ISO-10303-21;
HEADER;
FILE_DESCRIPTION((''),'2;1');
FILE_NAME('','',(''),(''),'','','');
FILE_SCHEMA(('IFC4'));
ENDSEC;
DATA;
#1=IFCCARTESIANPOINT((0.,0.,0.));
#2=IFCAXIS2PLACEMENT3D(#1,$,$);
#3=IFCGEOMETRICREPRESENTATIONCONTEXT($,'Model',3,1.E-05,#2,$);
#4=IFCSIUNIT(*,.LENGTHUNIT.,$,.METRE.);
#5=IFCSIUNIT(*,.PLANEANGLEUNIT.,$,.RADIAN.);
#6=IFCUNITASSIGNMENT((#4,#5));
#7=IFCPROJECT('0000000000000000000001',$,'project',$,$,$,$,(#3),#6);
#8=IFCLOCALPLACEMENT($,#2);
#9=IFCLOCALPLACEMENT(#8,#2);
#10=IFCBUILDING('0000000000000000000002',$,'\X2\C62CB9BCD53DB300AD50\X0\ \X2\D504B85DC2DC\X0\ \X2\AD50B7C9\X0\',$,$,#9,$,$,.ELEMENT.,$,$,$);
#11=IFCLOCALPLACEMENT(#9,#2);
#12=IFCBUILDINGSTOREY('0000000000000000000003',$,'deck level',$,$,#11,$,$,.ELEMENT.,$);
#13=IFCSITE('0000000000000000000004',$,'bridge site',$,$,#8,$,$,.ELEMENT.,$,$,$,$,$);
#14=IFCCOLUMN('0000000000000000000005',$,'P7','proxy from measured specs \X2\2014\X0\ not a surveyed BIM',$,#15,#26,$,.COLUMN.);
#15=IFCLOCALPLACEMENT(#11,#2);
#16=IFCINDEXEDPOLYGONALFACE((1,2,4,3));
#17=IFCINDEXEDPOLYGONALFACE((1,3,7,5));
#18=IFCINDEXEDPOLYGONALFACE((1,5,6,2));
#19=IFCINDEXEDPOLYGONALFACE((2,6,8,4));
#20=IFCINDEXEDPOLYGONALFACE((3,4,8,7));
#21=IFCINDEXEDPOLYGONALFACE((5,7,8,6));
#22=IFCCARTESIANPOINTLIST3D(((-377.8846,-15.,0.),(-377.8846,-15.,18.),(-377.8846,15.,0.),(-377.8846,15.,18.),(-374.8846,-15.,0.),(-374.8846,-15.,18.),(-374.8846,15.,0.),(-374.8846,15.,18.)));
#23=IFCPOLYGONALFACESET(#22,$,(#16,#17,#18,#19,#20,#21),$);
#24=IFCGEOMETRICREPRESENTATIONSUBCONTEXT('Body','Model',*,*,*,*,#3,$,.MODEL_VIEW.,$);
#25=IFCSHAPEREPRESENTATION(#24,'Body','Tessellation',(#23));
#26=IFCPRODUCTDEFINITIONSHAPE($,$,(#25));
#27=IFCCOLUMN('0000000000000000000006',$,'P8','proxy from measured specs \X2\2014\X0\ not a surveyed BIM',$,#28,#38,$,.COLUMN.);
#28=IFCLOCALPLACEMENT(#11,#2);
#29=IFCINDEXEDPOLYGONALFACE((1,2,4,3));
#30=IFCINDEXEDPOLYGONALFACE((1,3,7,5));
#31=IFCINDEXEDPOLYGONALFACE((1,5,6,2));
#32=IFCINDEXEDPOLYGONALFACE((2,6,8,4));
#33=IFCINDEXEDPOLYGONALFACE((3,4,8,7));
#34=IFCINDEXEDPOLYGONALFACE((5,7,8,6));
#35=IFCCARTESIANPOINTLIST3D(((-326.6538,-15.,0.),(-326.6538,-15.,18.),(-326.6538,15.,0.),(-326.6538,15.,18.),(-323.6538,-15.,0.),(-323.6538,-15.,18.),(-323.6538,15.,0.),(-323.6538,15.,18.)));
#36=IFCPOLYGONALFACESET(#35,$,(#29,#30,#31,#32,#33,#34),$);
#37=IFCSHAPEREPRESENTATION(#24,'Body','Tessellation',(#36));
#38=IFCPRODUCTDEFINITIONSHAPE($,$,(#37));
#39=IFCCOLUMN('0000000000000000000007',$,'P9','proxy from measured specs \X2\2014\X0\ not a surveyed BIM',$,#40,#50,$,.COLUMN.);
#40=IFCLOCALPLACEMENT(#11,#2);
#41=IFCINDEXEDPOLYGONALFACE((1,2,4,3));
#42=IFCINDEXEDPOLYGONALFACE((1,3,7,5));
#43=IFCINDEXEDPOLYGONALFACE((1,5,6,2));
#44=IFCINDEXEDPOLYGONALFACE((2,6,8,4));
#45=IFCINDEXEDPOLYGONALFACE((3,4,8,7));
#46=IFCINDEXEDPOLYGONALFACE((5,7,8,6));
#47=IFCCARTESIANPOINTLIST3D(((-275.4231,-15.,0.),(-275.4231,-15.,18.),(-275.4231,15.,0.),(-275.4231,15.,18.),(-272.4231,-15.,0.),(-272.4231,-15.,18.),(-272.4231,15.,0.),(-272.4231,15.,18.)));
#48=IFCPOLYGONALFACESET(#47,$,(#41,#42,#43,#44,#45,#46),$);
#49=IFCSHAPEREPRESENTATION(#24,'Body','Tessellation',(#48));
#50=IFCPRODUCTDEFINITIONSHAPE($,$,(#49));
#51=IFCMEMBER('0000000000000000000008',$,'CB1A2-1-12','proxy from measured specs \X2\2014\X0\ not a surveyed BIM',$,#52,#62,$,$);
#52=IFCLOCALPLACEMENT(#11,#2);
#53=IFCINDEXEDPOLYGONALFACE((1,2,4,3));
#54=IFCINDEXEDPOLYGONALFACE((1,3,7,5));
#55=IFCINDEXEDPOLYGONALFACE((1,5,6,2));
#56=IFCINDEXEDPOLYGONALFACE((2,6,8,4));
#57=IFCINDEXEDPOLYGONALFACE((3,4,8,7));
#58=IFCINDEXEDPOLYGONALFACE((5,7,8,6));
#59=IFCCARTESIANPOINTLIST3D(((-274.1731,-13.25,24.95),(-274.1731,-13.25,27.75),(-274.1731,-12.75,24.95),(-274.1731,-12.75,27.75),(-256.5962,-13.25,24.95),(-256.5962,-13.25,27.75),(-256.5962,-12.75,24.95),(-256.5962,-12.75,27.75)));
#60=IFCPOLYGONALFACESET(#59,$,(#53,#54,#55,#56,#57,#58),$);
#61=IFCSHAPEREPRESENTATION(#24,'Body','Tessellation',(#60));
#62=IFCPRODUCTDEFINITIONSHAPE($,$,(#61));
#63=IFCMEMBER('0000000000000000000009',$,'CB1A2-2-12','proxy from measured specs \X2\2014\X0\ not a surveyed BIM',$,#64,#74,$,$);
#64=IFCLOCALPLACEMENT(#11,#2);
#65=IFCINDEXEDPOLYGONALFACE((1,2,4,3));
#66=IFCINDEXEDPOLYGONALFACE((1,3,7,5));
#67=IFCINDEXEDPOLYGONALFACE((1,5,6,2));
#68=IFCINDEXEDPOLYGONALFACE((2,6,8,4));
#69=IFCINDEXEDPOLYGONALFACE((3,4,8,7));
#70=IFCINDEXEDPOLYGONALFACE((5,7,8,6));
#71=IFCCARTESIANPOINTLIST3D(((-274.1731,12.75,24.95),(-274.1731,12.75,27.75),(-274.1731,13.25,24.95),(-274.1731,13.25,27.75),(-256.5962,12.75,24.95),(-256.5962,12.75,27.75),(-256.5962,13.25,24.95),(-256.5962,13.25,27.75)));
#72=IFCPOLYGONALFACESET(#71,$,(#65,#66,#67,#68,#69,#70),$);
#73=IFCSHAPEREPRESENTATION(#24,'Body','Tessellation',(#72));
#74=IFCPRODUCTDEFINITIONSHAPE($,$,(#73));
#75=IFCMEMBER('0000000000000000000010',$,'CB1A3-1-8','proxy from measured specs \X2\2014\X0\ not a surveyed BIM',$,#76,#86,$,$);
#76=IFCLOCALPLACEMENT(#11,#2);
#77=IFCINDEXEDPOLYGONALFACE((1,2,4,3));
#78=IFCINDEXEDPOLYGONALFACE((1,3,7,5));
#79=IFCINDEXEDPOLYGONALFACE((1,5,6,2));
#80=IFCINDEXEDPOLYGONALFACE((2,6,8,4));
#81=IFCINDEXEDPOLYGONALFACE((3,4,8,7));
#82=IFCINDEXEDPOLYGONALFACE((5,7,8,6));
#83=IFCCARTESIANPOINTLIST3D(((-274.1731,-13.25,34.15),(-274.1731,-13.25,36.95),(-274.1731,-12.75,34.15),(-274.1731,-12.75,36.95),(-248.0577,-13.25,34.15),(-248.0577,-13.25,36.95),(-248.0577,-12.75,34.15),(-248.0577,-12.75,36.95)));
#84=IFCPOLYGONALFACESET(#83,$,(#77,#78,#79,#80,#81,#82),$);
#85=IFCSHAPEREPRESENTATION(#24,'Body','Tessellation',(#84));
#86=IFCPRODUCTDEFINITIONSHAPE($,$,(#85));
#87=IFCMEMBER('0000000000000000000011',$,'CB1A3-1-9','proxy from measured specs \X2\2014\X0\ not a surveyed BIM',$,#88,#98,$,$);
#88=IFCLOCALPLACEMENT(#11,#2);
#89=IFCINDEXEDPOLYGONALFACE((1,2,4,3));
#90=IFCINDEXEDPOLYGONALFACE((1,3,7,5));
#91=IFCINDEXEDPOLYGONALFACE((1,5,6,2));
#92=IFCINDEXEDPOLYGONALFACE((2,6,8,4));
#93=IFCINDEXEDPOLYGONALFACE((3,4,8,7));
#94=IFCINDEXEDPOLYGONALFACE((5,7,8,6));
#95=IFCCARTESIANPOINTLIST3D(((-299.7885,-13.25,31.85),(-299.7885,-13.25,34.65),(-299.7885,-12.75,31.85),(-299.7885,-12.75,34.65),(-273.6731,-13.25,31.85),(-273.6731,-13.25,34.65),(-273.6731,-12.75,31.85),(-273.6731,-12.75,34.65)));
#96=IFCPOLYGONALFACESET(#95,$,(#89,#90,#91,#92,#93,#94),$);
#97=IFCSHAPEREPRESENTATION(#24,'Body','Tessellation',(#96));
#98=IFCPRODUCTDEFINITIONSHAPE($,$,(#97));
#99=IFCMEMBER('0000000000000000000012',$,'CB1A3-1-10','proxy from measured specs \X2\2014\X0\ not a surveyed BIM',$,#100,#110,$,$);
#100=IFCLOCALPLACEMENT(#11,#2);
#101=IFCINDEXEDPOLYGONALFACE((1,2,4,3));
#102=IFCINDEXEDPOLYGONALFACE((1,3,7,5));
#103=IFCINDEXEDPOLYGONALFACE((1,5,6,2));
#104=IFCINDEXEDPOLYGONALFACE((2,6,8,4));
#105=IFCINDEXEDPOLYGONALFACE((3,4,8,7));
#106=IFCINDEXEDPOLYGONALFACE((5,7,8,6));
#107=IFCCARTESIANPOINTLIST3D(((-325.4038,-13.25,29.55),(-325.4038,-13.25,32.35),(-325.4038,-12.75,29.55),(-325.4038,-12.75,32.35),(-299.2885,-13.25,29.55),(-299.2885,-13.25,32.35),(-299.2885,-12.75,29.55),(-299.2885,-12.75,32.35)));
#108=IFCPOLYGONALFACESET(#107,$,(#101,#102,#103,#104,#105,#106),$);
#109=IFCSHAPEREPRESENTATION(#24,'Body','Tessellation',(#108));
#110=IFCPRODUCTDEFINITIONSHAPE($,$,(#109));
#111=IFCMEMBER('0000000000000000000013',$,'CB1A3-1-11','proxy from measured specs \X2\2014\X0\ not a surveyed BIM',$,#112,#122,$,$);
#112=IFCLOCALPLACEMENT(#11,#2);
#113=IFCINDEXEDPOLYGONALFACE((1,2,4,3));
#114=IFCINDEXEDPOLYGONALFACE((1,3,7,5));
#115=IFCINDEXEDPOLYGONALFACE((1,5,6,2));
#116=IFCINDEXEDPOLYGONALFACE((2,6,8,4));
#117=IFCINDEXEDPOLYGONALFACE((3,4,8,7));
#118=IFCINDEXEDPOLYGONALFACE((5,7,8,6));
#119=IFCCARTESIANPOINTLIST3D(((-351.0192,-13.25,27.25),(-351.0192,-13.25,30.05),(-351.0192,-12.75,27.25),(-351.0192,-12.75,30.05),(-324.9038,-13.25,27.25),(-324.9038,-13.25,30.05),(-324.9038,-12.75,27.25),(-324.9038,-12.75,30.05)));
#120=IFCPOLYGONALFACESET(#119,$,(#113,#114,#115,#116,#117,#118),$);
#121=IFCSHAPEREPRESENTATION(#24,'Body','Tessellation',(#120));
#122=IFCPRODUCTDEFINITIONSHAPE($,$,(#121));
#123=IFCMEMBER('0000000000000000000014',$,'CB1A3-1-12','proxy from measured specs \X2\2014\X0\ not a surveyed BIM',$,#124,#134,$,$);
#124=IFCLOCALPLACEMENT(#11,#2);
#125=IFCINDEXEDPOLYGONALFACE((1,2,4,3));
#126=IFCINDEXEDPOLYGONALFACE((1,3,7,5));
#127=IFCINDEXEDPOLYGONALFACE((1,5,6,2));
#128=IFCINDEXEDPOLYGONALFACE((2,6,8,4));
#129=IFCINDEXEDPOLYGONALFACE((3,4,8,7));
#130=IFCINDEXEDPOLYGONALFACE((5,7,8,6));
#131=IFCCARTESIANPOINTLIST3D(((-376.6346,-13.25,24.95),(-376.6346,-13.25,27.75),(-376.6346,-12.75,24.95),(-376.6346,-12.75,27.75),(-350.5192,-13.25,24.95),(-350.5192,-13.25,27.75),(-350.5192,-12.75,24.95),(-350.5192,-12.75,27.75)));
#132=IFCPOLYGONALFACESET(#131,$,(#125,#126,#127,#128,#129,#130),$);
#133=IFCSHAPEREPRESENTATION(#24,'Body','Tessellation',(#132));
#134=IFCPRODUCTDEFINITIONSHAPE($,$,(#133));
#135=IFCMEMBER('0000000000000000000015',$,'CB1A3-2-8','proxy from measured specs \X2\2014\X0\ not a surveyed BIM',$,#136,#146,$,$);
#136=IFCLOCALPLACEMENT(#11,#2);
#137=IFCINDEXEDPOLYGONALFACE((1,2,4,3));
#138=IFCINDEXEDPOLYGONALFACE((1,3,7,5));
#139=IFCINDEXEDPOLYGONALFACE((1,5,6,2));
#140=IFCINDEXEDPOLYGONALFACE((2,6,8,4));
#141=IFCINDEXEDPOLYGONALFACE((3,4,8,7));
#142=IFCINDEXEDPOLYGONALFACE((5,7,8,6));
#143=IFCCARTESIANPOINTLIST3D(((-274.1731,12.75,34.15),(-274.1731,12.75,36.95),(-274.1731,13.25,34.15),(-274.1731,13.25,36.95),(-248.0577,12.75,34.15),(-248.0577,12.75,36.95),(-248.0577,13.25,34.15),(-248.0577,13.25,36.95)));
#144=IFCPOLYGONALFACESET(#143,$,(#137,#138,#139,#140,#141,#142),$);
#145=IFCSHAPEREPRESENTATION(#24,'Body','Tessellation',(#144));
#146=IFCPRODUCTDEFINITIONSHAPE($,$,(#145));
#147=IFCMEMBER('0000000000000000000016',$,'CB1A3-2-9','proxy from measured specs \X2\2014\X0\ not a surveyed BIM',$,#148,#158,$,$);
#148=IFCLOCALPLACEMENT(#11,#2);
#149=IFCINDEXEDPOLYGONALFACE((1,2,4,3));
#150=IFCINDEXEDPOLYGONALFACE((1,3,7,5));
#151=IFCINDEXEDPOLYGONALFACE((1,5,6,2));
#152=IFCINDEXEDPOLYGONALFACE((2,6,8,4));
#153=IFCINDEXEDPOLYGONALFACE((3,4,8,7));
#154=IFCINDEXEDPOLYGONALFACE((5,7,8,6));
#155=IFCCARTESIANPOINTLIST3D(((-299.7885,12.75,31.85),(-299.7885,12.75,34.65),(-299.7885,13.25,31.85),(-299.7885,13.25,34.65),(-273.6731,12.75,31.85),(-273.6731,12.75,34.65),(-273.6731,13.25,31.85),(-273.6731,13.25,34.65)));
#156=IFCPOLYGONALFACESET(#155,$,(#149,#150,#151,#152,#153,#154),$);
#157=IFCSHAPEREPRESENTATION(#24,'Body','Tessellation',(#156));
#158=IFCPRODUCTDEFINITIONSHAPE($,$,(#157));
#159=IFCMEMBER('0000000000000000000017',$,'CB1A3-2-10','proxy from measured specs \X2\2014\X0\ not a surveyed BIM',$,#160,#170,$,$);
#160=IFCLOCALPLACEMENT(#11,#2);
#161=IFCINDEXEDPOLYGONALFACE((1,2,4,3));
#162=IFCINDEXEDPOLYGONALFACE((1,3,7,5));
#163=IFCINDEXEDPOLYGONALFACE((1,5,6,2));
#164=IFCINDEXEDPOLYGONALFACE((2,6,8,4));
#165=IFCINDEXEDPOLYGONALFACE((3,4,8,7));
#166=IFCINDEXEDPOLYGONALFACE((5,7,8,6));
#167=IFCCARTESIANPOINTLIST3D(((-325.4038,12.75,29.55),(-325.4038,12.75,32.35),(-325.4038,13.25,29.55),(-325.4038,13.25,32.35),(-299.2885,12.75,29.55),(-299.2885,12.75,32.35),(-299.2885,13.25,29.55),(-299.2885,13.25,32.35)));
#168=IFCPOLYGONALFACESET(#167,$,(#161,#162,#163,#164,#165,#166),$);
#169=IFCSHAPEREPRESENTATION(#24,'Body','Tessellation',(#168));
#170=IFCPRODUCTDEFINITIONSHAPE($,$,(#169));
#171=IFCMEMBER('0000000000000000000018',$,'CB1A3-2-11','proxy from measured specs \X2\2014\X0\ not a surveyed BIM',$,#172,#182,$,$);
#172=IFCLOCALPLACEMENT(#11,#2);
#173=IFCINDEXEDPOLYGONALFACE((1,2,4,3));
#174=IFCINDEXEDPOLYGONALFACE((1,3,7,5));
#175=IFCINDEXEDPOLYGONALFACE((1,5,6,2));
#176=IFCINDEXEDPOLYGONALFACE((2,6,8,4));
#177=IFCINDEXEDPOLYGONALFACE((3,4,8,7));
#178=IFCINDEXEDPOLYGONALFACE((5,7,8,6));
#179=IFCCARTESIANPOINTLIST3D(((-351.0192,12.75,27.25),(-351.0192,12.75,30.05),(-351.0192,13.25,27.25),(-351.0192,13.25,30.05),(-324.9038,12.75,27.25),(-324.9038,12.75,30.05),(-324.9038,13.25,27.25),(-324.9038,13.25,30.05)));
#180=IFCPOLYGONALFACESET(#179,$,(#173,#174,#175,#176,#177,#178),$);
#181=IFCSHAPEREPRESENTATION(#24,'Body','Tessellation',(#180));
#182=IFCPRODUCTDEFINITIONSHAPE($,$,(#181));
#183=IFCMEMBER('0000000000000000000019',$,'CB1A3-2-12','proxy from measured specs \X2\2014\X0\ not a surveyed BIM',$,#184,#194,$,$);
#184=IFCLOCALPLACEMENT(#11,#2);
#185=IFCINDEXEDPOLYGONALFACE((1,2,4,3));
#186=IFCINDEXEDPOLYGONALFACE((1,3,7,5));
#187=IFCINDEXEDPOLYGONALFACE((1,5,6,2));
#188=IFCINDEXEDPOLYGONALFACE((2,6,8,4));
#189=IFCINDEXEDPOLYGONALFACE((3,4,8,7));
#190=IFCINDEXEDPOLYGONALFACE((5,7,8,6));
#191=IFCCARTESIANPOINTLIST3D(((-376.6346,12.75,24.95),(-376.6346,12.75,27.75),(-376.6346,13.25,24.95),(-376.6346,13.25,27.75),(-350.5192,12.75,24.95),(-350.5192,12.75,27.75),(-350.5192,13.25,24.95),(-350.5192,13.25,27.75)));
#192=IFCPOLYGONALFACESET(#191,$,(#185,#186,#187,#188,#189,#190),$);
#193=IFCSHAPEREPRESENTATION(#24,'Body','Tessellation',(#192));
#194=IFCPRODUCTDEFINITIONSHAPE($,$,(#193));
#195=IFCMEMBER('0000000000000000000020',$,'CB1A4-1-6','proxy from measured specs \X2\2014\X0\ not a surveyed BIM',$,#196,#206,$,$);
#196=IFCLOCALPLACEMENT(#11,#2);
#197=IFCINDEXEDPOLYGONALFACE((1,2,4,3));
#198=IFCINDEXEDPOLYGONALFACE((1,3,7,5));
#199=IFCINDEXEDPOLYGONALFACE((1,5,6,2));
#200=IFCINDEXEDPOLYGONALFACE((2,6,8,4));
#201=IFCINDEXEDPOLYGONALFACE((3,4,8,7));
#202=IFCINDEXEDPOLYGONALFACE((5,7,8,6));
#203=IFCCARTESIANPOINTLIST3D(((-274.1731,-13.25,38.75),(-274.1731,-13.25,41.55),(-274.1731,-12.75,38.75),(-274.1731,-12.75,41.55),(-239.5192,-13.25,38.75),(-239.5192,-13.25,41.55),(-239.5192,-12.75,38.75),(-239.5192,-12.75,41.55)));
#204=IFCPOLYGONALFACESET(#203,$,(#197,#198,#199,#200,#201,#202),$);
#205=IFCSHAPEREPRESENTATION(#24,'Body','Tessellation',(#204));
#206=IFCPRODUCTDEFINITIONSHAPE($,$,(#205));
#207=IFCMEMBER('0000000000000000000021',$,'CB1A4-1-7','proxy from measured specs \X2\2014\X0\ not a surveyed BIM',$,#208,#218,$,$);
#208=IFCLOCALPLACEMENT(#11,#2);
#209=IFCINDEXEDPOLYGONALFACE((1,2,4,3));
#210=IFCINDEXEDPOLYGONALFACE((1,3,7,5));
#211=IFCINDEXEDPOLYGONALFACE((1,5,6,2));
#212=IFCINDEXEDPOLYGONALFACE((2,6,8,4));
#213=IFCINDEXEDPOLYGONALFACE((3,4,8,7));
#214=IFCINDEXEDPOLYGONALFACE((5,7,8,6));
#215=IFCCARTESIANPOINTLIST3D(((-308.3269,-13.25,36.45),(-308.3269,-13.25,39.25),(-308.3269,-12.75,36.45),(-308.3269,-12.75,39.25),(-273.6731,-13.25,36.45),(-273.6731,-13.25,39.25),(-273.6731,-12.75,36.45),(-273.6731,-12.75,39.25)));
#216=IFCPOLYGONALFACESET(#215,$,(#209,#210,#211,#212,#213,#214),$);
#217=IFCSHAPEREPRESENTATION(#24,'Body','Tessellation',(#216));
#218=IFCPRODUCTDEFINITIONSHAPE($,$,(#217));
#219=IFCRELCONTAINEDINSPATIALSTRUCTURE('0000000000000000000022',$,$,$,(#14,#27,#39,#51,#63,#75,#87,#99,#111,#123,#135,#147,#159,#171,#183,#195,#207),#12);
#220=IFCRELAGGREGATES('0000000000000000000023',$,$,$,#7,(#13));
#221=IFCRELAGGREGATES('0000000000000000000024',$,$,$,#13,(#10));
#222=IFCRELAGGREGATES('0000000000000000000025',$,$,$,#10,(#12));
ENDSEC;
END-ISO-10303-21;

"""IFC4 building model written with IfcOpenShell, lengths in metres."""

from ifc_helpers import new_model, si_unit, frame, origin, origin_2d, place, context, subcontext, project, spatial, rectangle, extrude, element, save


model = new_model("IFC4")

# Units and contexts
model_context = context("Model", 3, precision=1e-05, world=origin())
body_context = subcontext(model_context, "Body", "Model", "MODEL_VIEW")
ifc_project = project(units=[si_unit("LENGTHUNIT", "METRE"), si_unit("PLANEANGLEUNIT", "RADIAN")], contexts=[model_context])

# Site, building, storey
site_placement = place(None, origin())
site = spatial("IfcSite", under=ifc_project, at=site_placement, Name="bridge site", CompositionType="ELEMENT")
building_placement = place(site_placement, origin())
building = spatial("IfcBuilding", under=site, at=building_placement, Name="올림픽대교 프록시 교량", CompositionType="ELEMENT")
storey_placement = place(building_placement, origin())
storey = spatial("IfcBuildingStorey", under=building, at=storey_placement, Name="deck level", CompositionType="ELEMENT")

# Columns
for number, where, name in (
    (1, (-376.3846, 0.0, 0.0), "P7"),
    (2, (-325.1538, 0.0, 0.0), "P8"),
    (3, (-273.9231, 0.0, 0.0), "P9"),
):
    element("IfcColumn", number, at=place(storey_placement, frame(where)), inside=storey, Name=name, Description="proxy from measured specs — not a surveyed BIM", PredefinedType="COLUMN", context=body_context, shape_type="SweptSolid", body=[
        extrude(rectangle(XDim=3.0, YDim=30.0, at=origin_2d()), origin(), (0.0, 0.0, 1.0), 18.0),
    ])

# Members
for number, where, name in (
    (4, (-265.3846, -13.0, 24.95), "CB1A2-1-12"),
    (5, (-265.3846, 13.0, 24.95), "CB1A2-2-12"),
):
    element("IfcMember", number, at=place(storey_placement, frame(where)), inside=storey, Name=name, Description="proxy from measured specs — not a surveyed BIM", context=body_context, shape_type="SweptSolid", body=[
        extrude(rectangle(XDim=17.5769, YDim=0.5, at=origin_2d()), origin(), (0.0, 0.0, 1.0), 2.8),
    ])
member_1_placement = place(storey_placement, frame((-261.1154, -13.0, 34.15)))
element("IfcMember", 6, at=member_1_placement, inside=storey, Name="CB1A3-1-8", Description="proxy from measured specs — not a surveyed BIM", context=body_context, shape_type="SweptSolid", body=[
    extrude(rectangle(XDim=26.1154, YDim=0.5, at=origin_2d()), origin(), (0.0, 0.0, 1.0), 2.8),
])
member_2_placement = place(storey_placement, frame((-286.7308, -13.0, 31.85)))
element("IfcMember", 7, at=member_2_placement, inside=storey, Name="CB1A3-1-9", Description="proxy from measured specs — not a surveyed BIM", context=body_context, shape_type="SweptSolid", body=[
    extrude(rectangle(XDim=26.1154, YDim=0.5, at=origin_2d()), origin(), (0.0, 0.0, 1.0), 2.8),
])
member_3_placement = place(storey_placement, frame((-312.3462, -13.0, 29.55)))
element("IfcMember", 8, at=member_3_placement, inside=storey, Name="CB1A3-1-10", Description="proxy from measured specs — not a surveyed BIM", context=body_context, shape_type="SweptSolid", body=[
    extrude(rectangle(XDim=26.1154, YDim=0.5, at=origin_2d()), origin(), (0.0, 0.0, 1.0), 2.8),
])
member_4_placement = place(storey_placement, frame((-337.9615, -13.0, 27.25)))
element("IfcMember", 9, at=member_4_placement, inside=storey, Name="CB1A3-1-11", Description="proxy from measured specs — not a surveyed BIM", context=body_context, shape_type="SweptSolid", body=[
    extrude(rectangle(XDim=26.1154, YDim=0.5, at=origin_2d()), origin(), (0.0, 0.0, 1.0), 2.8),
])
member_5_placement = place(storey_placement, frame((-363.5769, -13.0, 24.95)))
element("IfcMember", 10, at=member_5_placement, inside=storey, Name="CB1A3-1-12", Description="proxy from measured specs — not a surveyed BIM", context=body_context, shape_type="SweptSolid", body=[
    extrude(rectangle(XDim=26.1154, YDim=0.5, at=origin_2d()), origin(), (0.0, 0.0, 1.0), 2.8),
])
member_6_placement = place(storey_placement, frame((-261.1154, 13.0, 34.15)))
element("IfcMember", 11, at=member_6_placement, inside=storey, Name="CB1A3-2-8", Description="proxy from measured specs — not a surveyed BIM", context=body_context, shape_type="SweptSolid", body=[
    extrude(rectangle(XDim=26.1154, YDim=0.5, at=origin_2d()), origin(), (0.0, 0.0, 1.0), 2.8),
])
member_7_placement = place(storey_placement, frame((-286.7308, 13.0, 31.85)))
element("IfcMember", 12, at=member_7_placement, inside=storey, Name="CB1A3-2-9", Description="proxy from measured specs — not a surveyed BIM", context=body_context, shape_type="SweptSolid", body=[
    extrude(rectangle(XDim=26.1154, YDim=0.5, at=origin_2d()), origin(), (0.0, 0.0, 1.0), 2.8),
])
member_8_placement = place(storey_placement, frame((-312.3462, 13.0, 29.55)))
element("IfcMember", 13, at=member_8_placement, inside=storey, Name="CB1A3-2-10", Description="proxy from measured specs — not a surveyed BIM", context=body_context, shape_type="SweptSolid", body=[
    extrude(rectangle(XDim=26.1154, YDim=0.5, at=origin_2d()), origin(), (0.0, 0.0, 1.0), 2.8),
])
member_9_placement = place(storey_placement, frame((-337.9615, 13.0, 27.25)))
element("IfcMember", 14, at=member_9_placement, inside=storey, Name="CB1A3-2-11", Description="proxy from measured specs — not a surveyed BIM", context=body_context, shape_type="SweptSolid", body=[
    extrude(rectangle(XDim=26.1154, YDim=0.5, at=origin_2d()), origin(), (0.0, 0.0, 1.0), 2.8),
])
member_10_placement = place(storey_placement, frame((-363.5769, 13.0, 24.95)))
element("IfcMember", 15, at=member_10_placement, inside=storey, Name="CB1A3-2-12", Description="proxy from measured specs — not a surveyed BIM", context=body_context, shape_type="SweptSolid", body=[
    extrude(rectangle(XDim=26.1154, YDim=0.5, at=origin_2d()), origin(), (0.0, 0.0, 1.0), 2.8),
])
member_11_placement = place(storey_placement, frame((-256.8462, -13.0, 38.75)))
element("IfcMember", 16, at=member_11_placement, inside=storey, Name="CB1A4-1-6", Description="proxy from measured specs — not a surveyed BIM", context=body_context, shape_type="SweptSolid", body=[
    extrude(rectangle(XDim=34.6538, YDim=0.5, at=origin_2d()), origin(), (0.0, 0.0, 1.0), 2.8),
])
member_12_placement = place(storey_placement, frame((-291.0, -13.0, 36.45)))
element("IfcMember", 17, at=member_12_placement, inside=storey, Name="CB1A4-1-7", Description="proxy from measured specs — not a surveyed BIM", context=body_context, shape_type="SweptSolid", body=[
    extrude(rectangle(XDim=34.6538, YDim=0.5, at=origin_2d()), origin(), (0.0, 0.0, 1.0), 2.8),
])

save(model, "model.ifc")
